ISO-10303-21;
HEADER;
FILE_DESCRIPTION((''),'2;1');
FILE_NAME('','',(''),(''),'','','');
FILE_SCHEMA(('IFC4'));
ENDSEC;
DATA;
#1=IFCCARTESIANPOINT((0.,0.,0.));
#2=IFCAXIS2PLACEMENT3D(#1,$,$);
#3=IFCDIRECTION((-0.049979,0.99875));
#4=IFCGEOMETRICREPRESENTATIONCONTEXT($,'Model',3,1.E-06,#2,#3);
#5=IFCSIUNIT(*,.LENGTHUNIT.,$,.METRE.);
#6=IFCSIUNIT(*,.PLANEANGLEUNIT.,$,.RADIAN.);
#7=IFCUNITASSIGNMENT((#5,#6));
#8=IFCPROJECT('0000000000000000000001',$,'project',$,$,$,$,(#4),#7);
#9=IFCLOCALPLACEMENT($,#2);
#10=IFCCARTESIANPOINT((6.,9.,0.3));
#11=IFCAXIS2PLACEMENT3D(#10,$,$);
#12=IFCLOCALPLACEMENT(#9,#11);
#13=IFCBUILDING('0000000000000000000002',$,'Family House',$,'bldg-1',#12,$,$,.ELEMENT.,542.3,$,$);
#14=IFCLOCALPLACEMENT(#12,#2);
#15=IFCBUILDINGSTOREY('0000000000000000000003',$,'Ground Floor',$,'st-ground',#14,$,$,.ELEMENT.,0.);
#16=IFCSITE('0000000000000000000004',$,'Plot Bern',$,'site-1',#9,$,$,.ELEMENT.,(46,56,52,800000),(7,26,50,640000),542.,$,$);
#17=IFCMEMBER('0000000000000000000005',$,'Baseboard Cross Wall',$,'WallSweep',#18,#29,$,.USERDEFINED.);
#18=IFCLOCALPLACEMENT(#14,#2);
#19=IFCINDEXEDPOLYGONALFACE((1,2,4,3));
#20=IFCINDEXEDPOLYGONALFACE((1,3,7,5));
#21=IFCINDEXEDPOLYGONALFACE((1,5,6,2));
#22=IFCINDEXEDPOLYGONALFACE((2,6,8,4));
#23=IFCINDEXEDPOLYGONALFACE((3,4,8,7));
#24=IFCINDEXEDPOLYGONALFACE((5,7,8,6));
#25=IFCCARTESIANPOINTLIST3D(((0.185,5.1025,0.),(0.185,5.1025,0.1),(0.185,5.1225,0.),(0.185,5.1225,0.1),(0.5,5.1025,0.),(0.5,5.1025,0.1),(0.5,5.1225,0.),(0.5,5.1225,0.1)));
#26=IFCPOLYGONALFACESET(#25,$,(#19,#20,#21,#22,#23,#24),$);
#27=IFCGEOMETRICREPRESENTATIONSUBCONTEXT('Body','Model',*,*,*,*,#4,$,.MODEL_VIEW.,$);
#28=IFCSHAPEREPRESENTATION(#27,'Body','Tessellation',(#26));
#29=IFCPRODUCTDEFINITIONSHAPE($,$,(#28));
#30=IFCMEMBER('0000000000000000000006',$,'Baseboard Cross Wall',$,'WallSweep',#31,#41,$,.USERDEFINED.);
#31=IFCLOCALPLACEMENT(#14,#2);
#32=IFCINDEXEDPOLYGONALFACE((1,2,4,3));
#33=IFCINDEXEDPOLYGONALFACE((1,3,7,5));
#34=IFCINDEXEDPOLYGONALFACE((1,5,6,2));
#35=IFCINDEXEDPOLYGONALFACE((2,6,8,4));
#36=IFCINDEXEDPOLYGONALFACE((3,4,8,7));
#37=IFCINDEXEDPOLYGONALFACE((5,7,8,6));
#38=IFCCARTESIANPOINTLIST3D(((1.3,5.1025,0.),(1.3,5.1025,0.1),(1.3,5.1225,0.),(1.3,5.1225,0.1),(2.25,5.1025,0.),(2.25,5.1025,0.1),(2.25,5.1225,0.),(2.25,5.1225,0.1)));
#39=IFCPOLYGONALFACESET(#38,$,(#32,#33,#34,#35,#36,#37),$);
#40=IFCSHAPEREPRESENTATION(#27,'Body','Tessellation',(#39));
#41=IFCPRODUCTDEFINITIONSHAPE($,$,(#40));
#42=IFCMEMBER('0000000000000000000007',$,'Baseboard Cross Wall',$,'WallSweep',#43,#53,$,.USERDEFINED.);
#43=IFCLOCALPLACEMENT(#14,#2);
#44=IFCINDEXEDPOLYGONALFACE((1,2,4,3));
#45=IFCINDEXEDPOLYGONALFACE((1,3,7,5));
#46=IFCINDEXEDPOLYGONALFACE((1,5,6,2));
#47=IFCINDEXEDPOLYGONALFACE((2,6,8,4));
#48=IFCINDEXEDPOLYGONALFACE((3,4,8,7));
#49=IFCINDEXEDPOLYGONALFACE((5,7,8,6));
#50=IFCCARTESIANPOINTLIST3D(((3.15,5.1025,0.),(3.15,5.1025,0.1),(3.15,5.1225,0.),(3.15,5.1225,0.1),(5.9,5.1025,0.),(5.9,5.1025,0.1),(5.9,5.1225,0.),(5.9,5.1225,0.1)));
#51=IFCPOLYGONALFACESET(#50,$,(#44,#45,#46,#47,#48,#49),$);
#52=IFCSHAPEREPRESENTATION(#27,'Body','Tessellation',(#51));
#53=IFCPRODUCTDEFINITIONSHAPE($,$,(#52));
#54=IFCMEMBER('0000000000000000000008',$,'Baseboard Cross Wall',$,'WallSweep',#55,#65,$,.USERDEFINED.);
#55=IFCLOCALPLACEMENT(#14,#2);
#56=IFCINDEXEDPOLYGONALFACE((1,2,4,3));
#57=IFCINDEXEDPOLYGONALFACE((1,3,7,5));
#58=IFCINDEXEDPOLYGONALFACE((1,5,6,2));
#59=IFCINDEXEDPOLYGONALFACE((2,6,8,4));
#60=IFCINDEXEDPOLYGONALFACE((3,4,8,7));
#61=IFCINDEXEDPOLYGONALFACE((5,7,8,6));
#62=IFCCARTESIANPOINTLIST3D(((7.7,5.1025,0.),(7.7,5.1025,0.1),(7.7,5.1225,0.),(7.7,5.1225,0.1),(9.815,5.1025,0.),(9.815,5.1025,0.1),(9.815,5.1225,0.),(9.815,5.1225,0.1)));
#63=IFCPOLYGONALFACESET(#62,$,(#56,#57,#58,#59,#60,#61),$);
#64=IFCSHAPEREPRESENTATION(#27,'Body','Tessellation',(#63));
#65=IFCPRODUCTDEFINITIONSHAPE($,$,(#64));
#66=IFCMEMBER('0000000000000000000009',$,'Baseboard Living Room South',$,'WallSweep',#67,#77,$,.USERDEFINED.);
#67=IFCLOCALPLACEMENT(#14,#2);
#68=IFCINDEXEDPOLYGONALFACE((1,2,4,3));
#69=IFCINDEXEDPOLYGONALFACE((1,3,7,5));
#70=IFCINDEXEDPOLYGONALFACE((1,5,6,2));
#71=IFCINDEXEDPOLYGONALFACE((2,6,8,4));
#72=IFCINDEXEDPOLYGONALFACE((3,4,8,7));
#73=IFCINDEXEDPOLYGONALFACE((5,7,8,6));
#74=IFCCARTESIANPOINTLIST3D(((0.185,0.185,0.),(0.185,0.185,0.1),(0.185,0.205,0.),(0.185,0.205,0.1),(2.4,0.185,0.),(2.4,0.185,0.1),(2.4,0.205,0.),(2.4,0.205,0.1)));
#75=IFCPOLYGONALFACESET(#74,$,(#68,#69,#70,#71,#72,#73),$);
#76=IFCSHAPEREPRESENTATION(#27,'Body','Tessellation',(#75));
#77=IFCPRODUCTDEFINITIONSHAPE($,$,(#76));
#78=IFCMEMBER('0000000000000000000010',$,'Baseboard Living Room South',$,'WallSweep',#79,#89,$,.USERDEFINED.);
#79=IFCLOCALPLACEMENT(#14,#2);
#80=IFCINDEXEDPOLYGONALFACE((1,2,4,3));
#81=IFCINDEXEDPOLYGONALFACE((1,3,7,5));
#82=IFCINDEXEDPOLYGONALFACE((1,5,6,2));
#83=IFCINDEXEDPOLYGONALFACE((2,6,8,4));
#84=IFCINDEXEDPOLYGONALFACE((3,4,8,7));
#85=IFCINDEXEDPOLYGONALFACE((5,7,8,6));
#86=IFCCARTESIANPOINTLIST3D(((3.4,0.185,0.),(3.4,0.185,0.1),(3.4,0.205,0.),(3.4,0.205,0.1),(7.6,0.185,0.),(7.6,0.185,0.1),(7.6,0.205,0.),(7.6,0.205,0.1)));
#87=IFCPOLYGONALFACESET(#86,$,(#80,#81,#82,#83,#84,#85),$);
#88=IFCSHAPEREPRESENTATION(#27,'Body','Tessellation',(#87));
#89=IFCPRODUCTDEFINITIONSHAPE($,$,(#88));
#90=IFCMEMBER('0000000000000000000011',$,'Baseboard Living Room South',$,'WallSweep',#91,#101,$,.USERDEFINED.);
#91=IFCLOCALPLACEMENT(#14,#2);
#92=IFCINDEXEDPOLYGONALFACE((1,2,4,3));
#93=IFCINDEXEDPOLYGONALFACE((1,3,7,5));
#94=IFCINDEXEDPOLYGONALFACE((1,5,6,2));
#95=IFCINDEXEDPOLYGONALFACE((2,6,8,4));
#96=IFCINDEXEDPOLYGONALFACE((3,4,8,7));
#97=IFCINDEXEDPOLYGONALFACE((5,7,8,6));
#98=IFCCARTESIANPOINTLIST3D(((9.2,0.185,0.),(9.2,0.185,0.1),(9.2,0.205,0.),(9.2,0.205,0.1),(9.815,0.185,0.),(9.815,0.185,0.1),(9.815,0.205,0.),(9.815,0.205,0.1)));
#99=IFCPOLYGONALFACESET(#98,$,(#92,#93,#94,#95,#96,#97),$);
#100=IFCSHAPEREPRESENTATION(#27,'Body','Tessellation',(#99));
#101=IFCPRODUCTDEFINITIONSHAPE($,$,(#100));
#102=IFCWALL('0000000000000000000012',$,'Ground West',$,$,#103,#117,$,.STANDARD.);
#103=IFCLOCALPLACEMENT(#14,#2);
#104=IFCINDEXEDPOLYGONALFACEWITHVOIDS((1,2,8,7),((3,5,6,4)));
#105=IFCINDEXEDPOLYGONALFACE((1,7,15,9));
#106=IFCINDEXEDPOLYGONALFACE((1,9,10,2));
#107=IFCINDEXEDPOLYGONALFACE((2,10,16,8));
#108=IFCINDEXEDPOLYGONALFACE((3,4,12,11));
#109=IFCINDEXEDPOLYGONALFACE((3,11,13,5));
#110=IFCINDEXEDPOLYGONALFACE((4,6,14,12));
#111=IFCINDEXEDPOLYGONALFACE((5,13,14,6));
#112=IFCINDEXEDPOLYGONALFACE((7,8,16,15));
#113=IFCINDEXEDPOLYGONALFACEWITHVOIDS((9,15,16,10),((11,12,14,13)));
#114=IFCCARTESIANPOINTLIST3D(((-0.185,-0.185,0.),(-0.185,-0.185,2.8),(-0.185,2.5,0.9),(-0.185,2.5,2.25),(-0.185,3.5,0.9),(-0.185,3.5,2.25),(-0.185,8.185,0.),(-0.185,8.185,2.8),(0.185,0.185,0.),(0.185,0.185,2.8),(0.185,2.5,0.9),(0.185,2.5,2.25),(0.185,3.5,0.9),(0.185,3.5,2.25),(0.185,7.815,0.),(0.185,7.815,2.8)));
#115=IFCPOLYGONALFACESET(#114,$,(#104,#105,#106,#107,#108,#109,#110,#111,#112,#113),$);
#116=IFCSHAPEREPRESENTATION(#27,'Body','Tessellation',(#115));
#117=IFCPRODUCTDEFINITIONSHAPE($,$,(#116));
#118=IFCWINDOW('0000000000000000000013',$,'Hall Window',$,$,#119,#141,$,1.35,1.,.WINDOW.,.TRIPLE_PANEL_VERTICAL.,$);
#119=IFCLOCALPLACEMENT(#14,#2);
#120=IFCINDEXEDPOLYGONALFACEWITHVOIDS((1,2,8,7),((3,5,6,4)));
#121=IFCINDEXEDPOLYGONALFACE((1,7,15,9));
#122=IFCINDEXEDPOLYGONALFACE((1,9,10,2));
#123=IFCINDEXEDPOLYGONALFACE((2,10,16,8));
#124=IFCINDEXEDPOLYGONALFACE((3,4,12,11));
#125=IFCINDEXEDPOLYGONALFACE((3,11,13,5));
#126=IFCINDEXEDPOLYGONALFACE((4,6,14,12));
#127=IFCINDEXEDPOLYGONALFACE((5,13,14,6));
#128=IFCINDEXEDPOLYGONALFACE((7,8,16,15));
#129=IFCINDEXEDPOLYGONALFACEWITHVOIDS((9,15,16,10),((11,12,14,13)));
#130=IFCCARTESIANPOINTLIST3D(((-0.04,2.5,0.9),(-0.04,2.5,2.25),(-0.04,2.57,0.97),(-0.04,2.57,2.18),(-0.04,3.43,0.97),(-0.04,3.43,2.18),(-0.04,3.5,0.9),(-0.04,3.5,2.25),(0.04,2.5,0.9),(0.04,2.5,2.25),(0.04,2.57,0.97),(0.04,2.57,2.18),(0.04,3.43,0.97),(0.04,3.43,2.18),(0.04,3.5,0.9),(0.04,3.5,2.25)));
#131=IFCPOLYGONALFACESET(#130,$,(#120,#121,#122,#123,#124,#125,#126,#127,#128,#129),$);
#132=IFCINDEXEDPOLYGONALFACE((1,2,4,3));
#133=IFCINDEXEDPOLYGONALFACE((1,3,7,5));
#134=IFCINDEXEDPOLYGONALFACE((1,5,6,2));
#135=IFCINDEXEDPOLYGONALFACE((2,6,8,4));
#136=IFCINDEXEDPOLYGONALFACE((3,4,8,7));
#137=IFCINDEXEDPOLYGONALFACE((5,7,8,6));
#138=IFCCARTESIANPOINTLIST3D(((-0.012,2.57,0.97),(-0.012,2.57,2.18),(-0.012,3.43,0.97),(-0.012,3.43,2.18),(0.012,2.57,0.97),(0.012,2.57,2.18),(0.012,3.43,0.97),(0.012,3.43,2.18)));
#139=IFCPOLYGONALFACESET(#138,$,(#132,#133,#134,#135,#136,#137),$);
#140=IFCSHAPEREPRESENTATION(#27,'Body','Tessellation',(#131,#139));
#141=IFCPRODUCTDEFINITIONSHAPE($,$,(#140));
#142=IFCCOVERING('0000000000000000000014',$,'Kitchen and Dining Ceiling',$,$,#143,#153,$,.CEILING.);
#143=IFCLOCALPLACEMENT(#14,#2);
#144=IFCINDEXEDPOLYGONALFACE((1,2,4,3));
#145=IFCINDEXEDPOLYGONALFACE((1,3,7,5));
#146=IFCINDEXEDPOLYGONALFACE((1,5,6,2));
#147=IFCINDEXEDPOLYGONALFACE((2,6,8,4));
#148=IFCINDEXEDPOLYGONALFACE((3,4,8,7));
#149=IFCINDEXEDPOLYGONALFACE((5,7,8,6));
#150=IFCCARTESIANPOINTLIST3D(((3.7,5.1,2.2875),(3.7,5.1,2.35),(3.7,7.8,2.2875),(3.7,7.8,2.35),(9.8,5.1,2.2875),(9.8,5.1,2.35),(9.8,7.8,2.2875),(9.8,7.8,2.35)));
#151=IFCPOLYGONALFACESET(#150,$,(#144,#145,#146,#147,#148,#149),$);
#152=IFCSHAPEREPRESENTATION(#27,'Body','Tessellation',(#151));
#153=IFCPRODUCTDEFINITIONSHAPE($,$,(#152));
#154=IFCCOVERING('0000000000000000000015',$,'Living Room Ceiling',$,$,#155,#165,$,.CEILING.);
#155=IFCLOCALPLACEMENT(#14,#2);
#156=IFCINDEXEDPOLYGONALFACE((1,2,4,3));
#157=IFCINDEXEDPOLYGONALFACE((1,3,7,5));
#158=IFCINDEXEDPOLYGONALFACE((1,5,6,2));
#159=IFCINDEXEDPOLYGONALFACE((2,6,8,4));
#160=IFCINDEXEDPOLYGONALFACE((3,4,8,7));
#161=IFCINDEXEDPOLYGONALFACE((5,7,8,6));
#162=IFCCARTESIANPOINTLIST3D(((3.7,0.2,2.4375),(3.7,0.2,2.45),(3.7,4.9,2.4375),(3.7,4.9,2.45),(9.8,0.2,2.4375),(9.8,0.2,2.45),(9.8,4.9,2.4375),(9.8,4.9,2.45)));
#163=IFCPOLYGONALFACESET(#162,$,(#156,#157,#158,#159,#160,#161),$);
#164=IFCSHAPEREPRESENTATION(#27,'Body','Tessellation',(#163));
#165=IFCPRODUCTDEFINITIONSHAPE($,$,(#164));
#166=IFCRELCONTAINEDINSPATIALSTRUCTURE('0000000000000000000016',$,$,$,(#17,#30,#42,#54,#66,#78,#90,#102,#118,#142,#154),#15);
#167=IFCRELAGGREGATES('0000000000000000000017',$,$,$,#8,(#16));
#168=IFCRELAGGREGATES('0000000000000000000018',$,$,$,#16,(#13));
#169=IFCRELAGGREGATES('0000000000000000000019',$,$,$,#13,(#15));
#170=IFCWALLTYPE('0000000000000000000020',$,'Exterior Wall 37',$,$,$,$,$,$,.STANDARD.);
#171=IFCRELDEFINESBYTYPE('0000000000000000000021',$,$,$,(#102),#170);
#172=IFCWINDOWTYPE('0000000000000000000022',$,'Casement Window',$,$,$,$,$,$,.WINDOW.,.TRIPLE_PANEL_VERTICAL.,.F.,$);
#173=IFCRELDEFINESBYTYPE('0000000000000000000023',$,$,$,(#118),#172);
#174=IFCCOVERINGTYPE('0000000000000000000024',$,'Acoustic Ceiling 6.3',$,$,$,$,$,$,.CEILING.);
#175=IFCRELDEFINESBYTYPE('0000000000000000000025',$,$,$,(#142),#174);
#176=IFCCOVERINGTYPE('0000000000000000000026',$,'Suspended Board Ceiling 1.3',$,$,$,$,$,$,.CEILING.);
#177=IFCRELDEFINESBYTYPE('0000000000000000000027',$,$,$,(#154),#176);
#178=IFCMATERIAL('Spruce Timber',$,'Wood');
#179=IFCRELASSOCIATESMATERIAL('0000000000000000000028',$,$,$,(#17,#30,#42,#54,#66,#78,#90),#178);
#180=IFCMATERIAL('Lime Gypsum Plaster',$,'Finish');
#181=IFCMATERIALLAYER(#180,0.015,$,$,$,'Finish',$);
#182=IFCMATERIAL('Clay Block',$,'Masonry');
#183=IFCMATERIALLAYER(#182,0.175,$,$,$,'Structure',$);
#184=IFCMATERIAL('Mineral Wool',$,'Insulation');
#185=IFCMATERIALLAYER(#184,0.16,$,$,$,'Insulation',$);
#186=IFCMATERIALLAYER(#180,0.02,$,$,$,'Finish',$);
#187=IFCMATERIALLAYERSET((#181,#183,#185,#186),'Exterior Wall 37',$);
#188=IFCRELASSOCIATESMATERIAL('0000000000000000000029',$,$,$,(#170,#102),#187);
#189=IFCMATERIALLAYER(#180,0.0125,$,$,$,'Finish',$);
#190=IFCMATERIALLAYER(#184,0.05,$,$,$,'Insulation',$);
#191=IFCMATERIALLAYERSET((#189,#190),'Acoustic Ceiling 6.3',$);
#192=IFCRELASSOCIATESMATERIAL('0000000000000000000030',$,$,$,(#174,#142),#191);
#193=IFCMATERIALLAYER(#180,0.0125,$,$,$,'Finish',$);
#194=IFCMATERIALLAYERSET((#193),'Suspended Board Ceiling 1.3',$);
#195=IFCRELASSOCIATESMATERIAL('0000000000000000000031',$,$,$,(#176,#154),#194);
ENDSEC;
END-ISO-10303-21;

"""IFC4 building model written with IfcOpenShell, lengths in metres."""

from ifc_helpers import new_model, si_unit, direction, frame, frame_2d, origin, origin_2d, place, context, subcontext, project, spatial, polyline, rectangle, outline, extrude, material, layer, layer_set, layer_usage, type_object, element, fill, save


model = new_model("IFC4")

# Units and contexts
model_context = context("Model", 3, precision=1e-06, world=origin(), true_north=direction((-0.049979, 0.99875)))
body_context = subcontext(model_context, "Body", "Model", "MODEL_VIEW")
ifc_project = project(units=[si_unit("LENGTHUNIT", "METRE"), si_unit("PLANEANGLEUNIT", "RADIAN")], contexts=[model_context])

# Site, building, storey
site_placement = place(None, origin())
site = spatial("IfcSite", under=ifc_project, at=site_placement, Name="Plot Bern", ObjectType="site-1", CompositionType="ELEMENT", RefLatitude=(46, 56, 52, 800000), RefLongitude=(7, 26, 50, 640000), RefElevation=542.0)
building_placement = place(site_placement, frame((6.0, 9.0, 0.3)))
building = spatial("IfcBuilding", under=site, at=building_placement, Name="Family House", ObjectType="bldg-1", CompositionType="ELEMENT", ElevationOfRefHeight=542.3)
storey_placement = place(building_placement, origin())
storey = spatial("IfcBuildingStorey", under=building, at=storey_placement, Name="Ground Floor", ObjectType="st-ground", CompositionType="ELEMENT", Elevation=0.0)

# Members
ifc_material_1 = material(Name="Spruce Timber", Category="Wood")
member_1_placement = place(storey_placement, origin())
element("IfcMember", 1, at=member_1_placement, inside=storey, material=ifc_material_1, Name="Baseboard Cross Wall", ObjectType="WallSweep", PredefinedType="USERDEFINED", context=body_context, shape_type="SweptSolid", body=[
    extrude(outline(polyline([(0.0, 0.0), (0.02, 0.0), (0.02, 0.1), (0.0, 0.1), (0.0, 0.0)])), frame((0.185, 5.1025, 0.0), z_axis=(1.0, 0.0, 0.0), x_axis=(0.0, 1.0, 0.0)), (0.0, 0.0, 1.0), 0.315),
])
member_2_placement = place(storey_placement, origin())
element("IfcMember", 2, at=member_2_placement, inside=storey, material=ifc_material_1, Name="Baseboard Cross Wall", ObjectType="WallSweep", PredefinedType="USERDEFINED", context=body_context, shape_type="SweptSolid", body=[
    extrude(outline(polyline([(0.0, 0.0), (0.02, 0.0), (0.02, 0.1), (0.0, 0.1), (0.0, 0.0)])), frame((1.3, 5.1025, 0.0), z_axis=(1.0, 0.0, 0.0), x_axis=(0.0, 1.0, 0.0)), (0.0, 0.0, 1.0), 0.95),
])
member_3_placement = place(storey_placement, origin())
element("IfcMember", 3, at=member_3_placement, inside=storey, material=ifc_material_1, Name="Baseboard Cross Wall", ObjectType="WallSweep", PredefinedType="USERDEFINED", context=body_context, shape_type="SweptSolid", body=[
    extrude(outline(polyline([(0.0, 0.0), (0.02, 0.0), (0.02, 0.1), (0.0, 0.1), (0.0, 0.0)])), frame((3.15, 5.1025, 0.0), z_axis=(1.0, 0.0, 0.0), x_axis=(0.0, 1.0, 0.0)), (0.0, 0.0, 1.0), 2.75),
])
member_4_placement = place(storey_placement, origin())
element("IfcMember", 4, at=member_4_placement, inside=storey, material=ifc_material_1, Name="Baseboard Cross Wall", ObjectType="WallSweep", PredefinedType="USERDEFINED", context=body_context, shape_type="SweptSolid", body=[
    extrude(outline(polyline([(0.0, 0.0), (0.02, 0.0), (0.02, 0.1), (0.0, 0.1), (0.0, 0.0)])), frame((7.7, 5.1025, 0.0), z_axis=(1.0, 0.0, 0.0), x_axis=(0.0, 1.0, 0.0)), (0.0, 0.0, 1.0), 2.115),
])
member_5_placement = place(storey_placement, origin())
element("IfcMember", 5, at=member_5_placement, inside=storey, material=ifc_material_1, Name="Baseboard Living Room South", ObjectType="WallSweep", PredefinedType="USERDEFINED", context=body_context, shape_type="SweptSolid", body=[
    extrude(outline(polyline([(0.0, 0.0), (0.02, 0.0), (0.02, 0.1), (0.0, 0.1), (0.0, 0.0)])), frame((0.185, 0.185, 0.0), z_axis=(1.0, 0.0, 0.0), x_axis=(0.0, 1.0, 0.0)), (0.0, 0.0, 1.0), 2.215),
])
member_6_placement = place(storey_placement, origin())
element("IfcMember", 6, at=member_6_placement, inside=storey, material=ifc_material_1, Name="Baseboard Living Room South", ObjectType="WallSweep", PredefinedType="USERDEFINED", context=body_context, shape_type="SweptSolid", body=[
    extrude(outline(polyline([(0.0, 0.0), (0.02, 0.0), (0.02, 0.1), (0.0, 0.1), (0.0, 0.0)])), frame((3.4, 0.185, 0.0), z_axis=(1.0, 0.0, 0.0), x_axis=(0.0, 1.0, 0.0)), (0.0, 0.0, 1.0), 4.2),
])
member_7_placement = place(storey_placement, origin())
element("IfcMember", 7, at=member_7_placement, inside=storey, material=ifc_material_1, Name="Baseboard Living Room South", ObjectType="WallSweep", PredefinedType="USERDEFINED", context=body_context, shape_type="SweptSolid", body=[
    extrude(outline(polyline([(0.0, 0.0), (0.02, 0.0), (0.02, 0.1), (0.0, 0.1), (0.0, 0.0)])), frame((9.2, 0.185, 0.0), z_axis=(1.0, 0.0, 0.0), x_axis=(0.0, 1.0, 0.0)), (0.0, 0.0, 1.0), 0.615),
])

# Wall, opening, window
ifc_material_2 = material(Name="Lime Gypsum Plaster", Category="Finish")
ifc_layer_1 = layer(ifc_material_2, 0.015, Category="Finish")
ifc_material_3 = material(Name="Clay Block", Category="Masonry")
ifc_layer_2 = layer(ifc_material_3, 0.175, Category="Structure")
ifc_material_4 = material(Name="Mineral Wool", Category="Insulation")
ifc_layer_3 = layer(ifc_material_4, 0.16, Category="Insulation")
ifc_layer_4 = layer(ifc_material_2, 0.02, Category="Finish")
ifc_layer_set_1 = layer_set([ifc_layer_1, ifc_layer_2, ifc_layer_3, ifc_layer_4], Name="Exterior Wall 37")
ifc_layer_usage_1 = layer_usage(ifc_layer_set_1, "AXIS2", "NEGATIVE", 0.185)
wall_type = type_object("IfcWallType", Name="Exterior Wall 37", PredefinedType="STANDARD", material=ifc_layer_set_1)
wall_placement = place(storey_placement, origin())
wall = element("IfcWall", 8, at=wall_placement, inside=storey, type_object=wall_type, material=ifc_layer_usage_1, Name="Ground West", PredefinedType="STANDARD", context=body_context, shape_type="SweptSolid", body=[
    extrude(outline(polyline([(-0.185, 8.185), (-0.185, -0.185), (0.185, 0.185), (0.185, 7.815), (-0.185, 8.185)])), origin(), (0.0, 0.0, 1.0), 2.8),
])
opening_placement = place(wall_placement, frame((0.0, 3.0, 0.9), z_axis=(0.0, 0.0, 1.0), x_axis=(0.0, -1.0, 0.0)))
opening = element("IfcOpeningElement", 9, at=opening_placement, cuts=wall, PredefinedType="OPENING", context=body_context, shape_type="SweptSolid", body=[
    extrude(rectangle(XDim=1.0, YDim=0.37, at=origin_2d()), origin(), (0.0, 0.0, 1.0), 1.35),
])
window_type = type_object("IfcWindowType", Name="Casement Window", ParameterTakesPrecedence=False, PartitioningType="TRIPLE_PANEL_VERTICAL", PredefinedType="WINDOW")
window_placement = place(opening_placement, frame((0.0, 0.0, 0.0), z_axis=(0.0, -1.0, 0.0), x_axis=(1.0, 0.0, 0.0)))
window = element("IfcWindow", 10, at=window_placement, inside=storey, type_object=window_type, Name="Hall Window", OverallHeight=1.35, OverallWidth=1.0, PartitioningType="TRIPLE_PANEL_VERTICAL", PredefinedType="WINDOW", context=body_context, shape_type="SweptSolid", body=[
    extrude(outline(polyline([(-0.5, 0.0), (0.5, 0.0), (0.5, 1.35), (-0.5, 1.35), (-0.5, 0.0)]), holes=[polyline([(-0.43, 0.07), (0.43, 0.07), (0.43, 1.28), (-0.43, 1.28), (-0.43, 0.07)])]), frame((0.0, 0.0, -0.04)), (0.0, 0.0, 1.0), 0.08),
    extrude(rectangle(XDim=0.86, YDim=1.21, at=frame_2d((0.0, 0.675))), frame((0.0, 0.0, -0.012)), (0.0, 0.0, 1.0), 0.024),
])
fill(opening, window)

# Coverings
ifc_layer_5 = layer(ifc_material_2, 0.0125, Category="Finish")
ifc_layer_6 = layer(ifc_material_4, 0.05, Category="Insulation")
ifc_layer_set_2 = layer_set([ifc_layer_5, ifc_layer_6], Name="Acoustic Ceiling 6.3")
ifc_layer_usage_2 = layer_usage(ifc_layer_set_2, "AXIS3", "NEGATIVE", 0.0625)
covering_type_1 = type_object("IfcCoveringType", Name="Acoustic Ceiling 6.3", PredefinedType="CEILING", material=ifc_layer_set_2)
covering_1_placement = place(storey_placement, frame((0.0, 0.0, 2.2875)))
element("IfcCovering", 11, at=covering_1_placement, inside=storey, type_object=covering_type_1, material=ifc_layer_usage_2, Name="Kitchen and Dining Ceiling", PredefinedType="CEILING", context=body_context, shape_type="SweptSolid", body=[
    extrude(outline(polyline([(3.7, 5.1), (9.8, 5.1), (9.8, 7.8), (3.7, 7.8), (3.7, 5.1)])), origin(), (0.0, 0.0, 1.0), 0.0625),
])
ifc_layer_7 = layer(ifc_material_2, 0.0125, Category="Finish")
ifc_layer_set_3 = layer_set([ifc_layer_7], Name="Suspended Board Ceiling 1.3")
ifc_layer_usage_3 = layer_usage(ifc_layer_set_3, "AXIS3", "NEGATIVE", 0.0125)
covering_type_2 = type_object("IfcCoveringType", Name="Suspended Board Ceiling 1.3", PredefinedType="CEILING", material=ifc_layer_set_3)
covering_2_placement = place(storey_placement, frame((0.0, 0.0, 2.4375)))
element("IfcCovering", 12, at=covering_2_placement, inside=storey, type_object=covering_type_2, material=ifc_layer_usage_3, Name="Living Room Ceiling", PredefinedType="CEILING", context=body_context, shape_type="SweptSolid", body=[
    extrude(outline(polyline([(3.7, 0.2), (9.8, 0.2), (9.8, 4.9), (3.7, 4.9), (3.7, 0.2)])), origin(), (0.0, 0.0, 1.0), 0.0125),
])

save(model, "model.ifc")
